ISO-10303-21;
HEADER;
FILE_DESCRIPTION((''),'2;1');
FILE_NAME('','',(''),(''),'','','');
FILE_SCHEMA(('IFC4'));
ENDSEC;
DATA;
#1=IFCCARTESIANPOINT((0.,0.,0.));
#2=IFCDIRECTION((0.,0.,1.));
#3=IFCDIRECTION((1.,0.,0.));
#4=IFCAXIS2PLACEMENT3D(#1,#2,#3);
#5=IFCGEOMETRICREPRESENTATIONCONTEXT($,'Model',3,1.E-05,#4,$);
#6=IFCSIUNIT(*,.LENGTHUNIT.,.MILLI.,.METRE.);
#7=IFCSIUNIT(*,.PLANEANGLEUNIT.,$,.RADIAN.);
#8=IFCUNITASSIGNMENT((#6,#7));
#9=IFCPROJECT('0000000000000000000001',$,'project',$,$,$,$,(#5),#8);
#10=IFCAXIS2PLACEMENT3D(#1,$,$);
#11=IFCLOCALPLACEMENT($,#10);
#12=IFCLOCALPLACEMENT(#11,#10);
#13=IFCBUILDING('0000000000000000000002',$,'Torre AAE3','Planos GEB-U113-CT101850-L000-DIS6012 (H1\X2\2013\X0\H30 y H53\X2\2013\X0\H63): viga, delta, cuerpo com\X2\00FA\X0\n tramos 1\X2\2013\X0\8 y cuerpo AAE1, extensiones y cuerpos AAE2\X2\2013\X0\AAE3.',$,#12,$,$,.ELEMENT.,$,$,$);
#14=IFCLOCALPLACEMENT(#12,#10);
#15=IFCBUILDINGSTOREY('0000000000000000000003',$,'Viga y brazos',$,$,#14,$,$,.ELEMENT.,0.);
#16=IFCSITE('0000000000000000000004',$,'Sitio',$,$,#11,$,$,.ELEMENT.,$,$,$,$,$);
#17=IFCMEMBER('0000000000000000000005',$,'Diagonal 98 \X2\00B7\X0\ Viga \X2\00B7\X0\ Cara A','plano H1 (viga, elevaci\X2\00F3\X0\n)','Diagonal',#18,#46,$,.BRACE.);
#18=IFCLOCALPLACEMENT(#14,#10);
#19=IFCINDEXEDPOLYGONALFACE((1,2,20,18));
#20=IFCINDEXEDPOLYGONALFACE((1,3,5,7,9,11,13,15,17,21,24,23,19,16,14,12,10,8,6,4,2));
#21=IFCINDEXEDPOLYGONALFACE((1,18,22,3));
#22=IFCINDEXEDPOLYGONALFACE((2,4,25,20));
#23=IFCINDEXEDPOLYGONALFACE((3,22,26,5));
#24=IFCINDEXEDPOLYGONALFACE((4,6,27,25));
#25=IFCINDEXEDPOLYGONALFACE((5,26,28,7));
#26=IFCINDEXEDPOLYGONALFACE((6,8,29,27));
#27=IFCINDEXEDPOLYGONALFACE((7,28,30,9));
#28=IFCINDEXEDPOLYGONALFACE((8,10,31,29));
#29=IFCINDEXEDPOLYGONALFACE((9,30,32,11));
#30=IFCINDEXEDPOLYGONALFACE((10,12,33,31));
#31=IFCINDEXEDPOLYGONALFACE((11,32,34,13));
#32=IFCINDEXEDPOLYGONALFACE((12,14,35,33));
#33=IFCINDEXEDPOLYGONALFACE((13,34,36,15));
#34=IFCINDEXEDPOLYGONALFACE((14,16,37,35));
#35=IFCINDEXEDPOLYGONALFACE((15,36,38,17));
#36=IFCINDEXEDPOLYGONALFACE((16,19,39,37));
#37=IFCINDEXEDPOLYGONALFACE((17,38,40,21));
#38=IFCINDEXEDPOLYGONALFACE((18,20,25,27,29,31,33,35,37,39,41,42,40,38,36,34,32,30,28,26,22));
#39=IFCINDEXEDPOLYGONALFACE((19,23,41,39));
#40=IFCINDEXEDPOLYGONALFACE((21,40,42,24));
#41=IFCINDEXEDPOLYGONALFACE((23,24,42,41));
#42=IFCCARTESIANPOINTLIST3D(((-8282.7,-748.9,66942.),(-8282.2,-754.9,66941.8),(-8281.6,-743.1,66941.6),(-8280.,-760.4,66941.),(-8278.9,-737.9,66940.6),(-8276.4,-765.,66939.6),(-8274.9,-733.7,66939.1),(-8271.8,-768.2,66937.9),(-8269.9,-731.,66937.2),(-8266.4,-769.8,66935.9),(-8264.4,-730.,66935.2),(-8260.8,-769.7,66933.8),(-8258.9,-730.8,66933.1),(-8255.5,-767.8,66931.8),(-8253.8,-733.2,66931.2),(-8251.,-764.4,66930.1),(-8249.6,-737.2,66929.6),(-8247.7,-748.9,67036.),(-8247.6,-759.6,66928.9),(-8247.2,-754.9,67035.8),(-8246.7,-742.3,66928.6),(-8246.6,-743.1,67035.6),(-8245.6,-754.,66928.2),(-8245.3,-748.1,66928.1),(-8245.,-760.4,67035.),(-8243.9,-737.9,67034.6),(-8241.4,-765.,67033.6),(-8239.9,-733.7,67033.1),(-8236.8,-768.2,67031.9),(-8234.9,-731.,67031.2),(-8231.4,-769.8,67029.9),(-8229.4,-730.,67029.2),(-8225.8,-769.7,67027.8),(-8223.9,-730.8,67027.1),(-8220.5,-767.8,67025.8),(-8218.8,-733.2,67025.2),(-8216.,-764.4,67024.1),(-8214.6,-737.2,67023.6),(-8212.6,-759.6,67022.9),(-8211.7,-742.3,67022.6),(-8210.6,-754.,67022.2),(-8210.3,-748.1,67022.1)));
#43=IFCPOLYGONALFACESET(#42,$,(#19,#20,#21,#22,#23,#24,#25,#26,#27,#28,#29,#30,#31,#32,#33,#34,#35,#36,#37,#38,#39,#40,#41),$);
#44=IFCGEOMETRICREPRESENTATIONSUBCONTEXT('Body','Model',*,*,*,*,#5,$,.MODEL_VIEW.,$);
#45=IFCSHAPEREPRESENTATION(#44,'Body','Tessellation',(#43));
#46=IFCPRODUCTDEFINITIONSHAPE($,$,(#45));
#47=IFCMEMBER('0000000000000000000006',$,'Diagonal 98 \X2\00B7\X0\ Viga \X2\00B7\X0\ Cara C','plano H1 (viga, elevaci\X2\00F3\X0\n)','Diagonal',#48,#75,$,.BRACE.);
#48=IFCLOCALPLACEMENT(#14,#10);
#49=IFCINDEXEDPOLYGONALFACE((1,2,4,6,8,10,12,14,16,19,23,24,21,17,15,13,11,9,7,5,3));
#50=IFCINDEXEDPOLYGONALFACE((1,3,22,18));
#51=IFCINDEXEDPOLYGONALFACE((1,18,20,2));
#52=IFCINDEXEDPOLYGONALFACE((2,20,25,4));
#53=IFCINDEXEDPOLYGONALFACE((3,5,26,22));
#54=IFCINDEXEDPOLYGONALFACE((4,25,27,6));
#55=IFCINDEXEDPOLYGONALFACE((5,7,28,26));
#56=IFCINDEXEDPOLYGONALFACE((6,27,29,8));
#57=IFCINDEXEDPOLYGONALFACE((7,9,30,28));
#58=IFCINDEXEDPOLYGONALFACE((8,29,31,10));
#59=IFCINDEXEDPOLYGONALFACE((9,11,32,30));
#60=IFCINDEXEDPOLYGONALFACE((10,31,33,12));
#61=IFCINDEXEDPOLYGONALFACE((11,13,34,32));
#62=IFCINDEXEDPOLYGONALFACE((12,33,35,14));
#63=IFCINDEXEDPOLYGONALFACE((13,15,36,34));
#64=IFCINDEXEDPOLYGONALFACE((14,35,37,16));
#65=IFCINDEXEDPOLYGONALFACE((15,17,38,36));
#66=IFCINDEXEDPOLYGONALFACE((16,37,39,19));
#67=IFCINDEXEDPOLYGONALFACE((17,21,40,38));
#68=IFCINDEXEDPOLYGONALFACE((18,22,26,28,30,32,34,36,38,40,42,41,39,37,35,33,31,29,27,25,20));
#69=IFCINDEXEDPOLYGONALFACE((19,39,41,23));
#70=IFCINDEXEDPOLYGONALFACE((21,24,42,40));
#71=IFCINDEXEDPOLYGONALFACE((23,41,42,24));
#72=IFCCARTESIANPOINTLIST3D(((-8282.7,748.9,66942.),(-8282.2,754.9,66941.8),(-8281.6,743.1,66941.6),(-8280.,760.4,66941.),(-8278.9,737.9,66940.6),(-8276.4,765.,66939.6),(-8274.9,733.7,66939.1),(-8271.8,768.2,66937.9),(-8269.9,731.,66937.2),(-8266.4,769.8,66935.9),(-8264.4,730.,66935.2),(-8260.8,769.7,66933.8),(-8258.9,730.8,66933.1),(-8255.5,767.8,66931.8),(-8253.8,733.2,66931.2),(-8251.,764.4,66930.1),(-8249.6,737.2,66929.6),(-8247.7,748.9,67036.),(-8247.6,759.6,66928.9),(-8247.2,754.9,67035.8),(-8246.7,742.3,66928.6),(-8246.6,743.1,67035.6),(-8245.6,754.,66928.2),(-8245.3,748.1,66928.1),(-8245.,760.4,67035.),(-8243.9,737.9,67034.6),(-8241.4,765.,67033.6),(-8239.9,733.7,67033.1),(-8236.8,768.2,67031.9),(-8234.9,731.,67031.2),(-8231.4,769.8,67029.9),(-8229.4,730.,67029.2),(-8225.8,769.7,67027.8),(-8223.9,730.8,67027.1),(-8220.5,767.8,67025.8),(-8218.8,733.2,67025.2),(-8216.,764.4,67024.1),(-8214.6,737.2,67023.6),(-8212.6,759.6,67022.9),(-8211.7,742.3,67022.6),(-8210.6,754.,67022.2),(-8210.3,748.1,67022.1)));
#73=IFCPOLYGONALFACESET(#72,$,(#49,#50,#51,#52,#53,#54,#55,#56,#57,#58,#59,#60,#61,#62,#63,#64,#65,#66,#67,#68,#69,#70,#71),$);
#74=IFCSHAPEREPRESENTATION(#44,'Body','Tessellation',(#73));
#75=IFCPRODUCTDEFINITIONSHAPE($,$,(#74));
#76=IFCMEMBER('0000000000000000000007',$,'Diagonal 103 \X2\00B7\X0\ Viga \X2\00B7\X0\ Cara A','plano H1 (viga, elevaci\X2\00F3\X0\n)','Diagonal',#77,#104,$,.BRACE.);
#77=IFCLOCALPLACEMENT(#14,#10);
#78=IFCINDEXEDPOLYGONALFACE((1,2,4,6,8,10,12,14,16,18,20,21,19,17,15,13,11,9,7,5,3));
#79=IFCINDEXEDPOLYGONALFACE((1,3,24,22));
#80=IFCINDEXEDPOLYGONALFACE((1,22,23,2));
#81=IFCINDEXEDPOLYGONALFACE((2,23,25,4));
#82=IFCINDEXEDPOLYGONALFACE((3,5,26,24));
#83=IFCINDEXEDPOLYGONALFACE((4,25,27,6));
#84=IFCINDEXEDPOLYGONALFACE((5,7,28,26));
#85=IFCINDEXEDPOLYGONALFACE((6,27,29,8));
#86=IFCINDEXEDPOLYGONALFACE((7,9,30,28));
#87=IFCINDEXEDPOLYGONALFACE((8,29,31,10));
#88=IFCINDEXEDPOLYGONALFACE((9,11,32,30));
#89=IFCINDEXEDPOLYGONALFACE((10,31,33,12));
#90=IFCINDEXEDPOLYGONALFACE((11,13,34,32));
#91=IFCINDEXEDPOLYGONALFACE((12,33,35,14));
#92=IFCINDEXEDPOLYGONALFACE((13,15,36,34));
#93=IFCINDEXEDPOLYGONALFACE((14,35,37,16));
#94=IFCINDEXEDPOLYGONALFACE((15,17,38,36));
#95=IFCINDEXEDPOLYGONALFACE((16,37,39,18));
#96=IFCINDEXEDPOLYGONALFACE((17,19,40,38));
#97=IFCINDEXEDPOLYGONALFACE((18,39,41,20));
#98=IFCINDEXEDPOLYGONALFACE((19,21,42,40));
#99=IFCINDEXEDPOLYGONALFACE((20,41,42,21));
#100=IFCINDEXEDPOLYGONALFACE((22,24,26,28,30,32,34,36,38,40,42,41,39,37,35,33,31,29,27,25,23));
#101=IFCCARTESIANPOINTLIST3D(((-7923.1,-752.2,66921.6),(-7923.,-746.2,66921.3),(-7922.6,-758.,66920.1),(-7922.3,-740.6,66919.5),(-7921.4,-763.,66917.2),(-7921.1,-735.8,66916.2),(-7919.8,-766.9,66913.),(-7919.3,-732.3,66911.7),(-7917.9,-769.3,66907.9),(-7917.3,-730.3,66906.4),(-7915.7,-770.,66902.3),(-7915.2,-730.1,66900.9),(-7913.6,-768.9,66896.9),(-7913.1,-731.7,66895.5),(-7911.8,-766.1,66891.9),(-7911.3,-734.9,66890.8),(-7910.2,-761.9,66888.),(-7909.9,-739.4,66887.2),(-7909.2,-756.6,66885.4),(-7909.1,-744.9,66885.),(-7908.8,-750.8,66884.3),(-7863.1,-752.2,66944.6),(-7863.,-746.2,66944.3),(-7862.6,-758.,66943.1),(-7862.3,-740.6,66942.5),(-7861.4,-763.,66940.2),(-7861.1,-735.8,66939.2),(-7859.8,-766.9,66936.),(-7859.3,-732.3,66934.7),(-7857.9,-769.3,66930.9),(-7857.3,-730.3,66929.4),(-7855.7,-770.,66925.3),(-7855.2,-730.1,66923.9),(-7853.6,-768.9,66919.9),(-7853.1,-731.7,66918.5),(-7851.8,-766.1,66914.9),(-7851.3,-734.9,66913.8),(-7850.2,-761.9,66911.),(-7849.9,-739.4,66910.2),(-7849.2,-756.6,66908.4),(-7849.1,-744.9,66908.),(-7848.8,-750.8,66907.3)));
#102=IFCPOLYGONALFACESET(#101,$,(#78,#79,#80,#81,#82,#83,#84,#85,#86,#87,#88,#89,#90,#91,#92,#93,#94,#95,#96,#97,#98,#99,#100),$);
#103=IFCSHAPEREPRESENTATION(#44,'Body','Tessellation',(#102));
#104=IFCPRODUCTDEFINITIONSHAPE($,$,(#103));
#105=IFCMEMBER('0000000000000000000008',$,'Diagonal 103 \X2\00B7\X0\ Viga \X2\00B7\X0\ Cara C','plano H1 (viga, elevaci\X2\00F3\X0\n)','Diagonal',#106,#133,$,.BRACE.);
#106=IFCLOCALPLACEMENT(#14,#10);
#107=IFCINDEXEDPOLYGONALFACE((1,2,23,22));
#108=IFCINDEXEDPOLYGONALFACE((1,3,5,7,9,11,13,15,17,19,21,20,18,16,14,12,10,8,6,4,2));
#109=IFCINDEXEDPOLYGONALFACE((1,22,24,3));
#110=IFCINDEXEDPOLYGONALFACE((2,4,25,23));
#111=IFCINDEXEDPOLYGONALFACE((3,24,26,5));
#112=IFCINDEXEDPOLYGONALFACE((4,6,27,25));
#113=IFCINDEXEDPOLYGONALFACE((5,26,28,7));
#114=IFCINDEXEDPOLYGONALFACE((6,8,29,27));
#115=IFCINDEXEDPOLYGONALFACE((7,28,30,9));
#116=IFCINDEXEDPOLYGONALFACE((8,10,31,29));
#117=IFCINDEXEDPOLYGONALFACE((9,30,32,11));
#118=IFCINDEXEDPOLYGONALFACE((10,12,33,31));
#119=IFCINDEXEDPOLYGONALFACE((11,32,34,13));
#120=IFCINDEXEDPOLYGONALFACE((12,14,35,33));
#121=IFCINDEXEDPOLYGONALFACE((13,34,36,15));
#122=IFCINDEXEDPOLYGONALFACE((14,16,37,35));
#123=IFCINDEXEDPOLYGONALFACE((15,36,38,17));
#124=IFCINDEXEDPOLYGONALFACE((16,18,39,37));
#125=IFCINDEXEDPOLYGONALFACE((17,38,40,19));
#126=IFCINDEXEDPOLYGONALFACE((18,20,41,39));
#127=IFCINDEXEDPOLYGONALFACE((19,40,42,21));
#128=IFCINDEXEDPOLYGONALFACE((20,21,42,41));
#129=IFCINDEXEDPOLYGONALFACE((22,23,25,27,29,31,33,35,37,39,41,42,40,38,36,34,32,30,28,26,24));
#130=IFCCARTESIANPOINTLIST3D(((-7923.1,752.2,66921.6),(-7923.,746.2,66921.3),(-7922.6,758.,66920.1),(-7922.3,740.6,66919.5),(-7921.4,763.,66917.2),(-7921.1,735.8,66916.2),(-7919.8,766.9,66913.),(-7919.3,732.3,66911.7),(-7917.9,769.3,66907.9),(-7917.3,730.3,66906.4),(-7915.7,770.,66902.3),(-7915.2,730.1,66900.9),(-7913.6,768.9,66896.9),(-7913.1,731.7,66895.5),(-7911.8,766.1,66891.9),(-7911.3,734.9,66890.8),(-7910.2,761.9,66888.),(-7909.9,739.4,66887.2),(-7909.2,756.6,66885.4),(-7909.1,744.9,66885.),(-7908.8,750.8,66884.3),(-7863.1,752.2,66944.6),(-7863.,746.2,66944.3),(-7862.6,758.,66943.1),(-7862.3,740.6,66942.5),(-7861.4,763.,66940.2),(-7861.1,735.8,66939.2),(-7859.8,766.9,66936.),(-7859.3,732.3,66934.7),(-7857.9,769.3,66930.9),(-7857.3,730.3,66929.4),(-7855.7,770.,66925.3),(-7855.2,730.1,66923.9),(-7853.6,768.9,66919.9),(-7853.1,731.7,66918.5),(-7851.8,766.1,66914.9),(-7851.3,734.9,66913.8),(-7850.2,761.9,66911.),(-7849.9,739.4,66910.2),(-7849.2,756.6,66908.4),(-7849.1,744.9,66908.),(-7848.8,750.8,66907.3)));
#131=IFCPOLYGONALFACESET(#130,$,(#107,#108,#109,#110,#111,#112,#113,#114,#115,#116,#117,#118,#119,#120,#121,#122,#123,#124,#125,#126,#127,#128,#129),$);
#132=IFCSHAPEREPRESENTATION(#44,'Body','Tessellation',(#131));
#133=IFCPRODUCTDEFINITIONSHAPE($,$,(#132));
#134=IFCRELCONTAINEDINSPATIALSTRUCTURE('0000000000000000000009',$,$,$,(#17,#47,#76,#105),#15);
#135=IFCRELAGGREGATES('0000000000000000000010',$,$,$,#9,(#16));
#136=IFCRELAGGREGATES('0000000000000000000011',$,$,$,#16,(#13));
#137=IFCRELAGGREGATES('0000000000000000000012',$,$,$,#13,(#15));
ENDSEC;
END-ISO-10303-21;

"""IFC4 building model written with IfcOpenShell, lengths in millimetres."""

from ifc_helpers import new_model, si_unit, frame, origin, origin_with_axes, place, context, subcontext, project, spatial, circle, extrude, element, save


model = new_model("IFC4")

# Units and contexts
model_context = context("Model", 3, precision=1e-05, world=origin_with_axes())
body_context = subcontext(model_context, "Body", "Model", "MODEL_VIEW")
ifc_project = project(units=[si_unit("LENGTHUNIT", "METRE", prefix="MILLI"), si_unit("PLANEANGLEUNIT", "RADIAN")], contexts=[model_context])

# Site, building, storey
site_placement = place(None, origin())
site = spatial("IfcSite", under=ifc_project, at=site_placement, Name="Sitio", CompositionType="ELEMENT")
building_placement = place(site_placement, origin())
building = spatial("IfcBuilding", under=site, at=building_placement, Name="Torre AAE3", Description="Planos GEB-U113-CT101850-L000-DIS6012 (H1–H30 y H53–H63): viga, delta, cuerpo común tramos 1–8 y cuerpo AAE1, extensiones y cuerpos AAE2–AAE3.", CompositionType="ELEMENT")
storey_placement = place(building_placement, origin())
storey = spatial("IfcBuildingStorey", under=building, at=storey_placement, Name="Viga y brazos", CompositionType="ELEMENT", Elevation=0.0)

# Members
for number, where, z_axis, x_axis, name in (
    (1, (-8264.0, -750.0, 66935.0), (0.348937, 0.0, 0.937146), (0.932764, 0.096594, -0.347306), "Diagonal 98 · Viga · Cara A"),
    (2, (-8264.0, 750.0, 66935.0), (0.348937, 0.0, 0.937146), (0.932764, -0.096594, -0.347306), "Diagonal 98 · Viga · Cara C"),
):
    element("IfcMember", number, at=place(storey_placement, frame(where, z_axis=z_axis, x_axis=x_axis)), inside=storey, Name=name, Description="plano H1 (viga, elevación)", ObjectType="Diagonal", PredefinedType="BRACE", context=body_context, shape_type="SweptSolid", body=[
        extrude(circle(Radius=20.0), None, (0.0, 0.0, 1.0), 100.3),
    ])
for number, where, z_axis, x_axis, name in (
    (3, (-7856.0, -750.0, 66926.0), (-0.933746, 0.0, -0.357936), (0.345933, 0.256794, -0.902434), "Diagonal 103 · Viga · Cara A"),
    (4, (-7856.0, 750.0, 66926.0), (-0.933746, 0.0, -0.357936), (0.345933, -0.256794, -0.902434), "Diagonal 103 · Viga · Cara C"),
):
    element("IfcMember", number, at=place(storey_placement, frame(where, z_axis=z_axis, x_axis=x_axis)), inside=storey, Name=name, Description="plano H1 (viga, elevación)", ObjectType="Diagonal", PredefinedType="BRACE", context=body_context, shape_type="SweptSolid", body=[
        extrude(circle(Radius=20.0), None, (0.0, 0.0, 1.0), 64.3),
    ])

save(model, "model.ifc")
